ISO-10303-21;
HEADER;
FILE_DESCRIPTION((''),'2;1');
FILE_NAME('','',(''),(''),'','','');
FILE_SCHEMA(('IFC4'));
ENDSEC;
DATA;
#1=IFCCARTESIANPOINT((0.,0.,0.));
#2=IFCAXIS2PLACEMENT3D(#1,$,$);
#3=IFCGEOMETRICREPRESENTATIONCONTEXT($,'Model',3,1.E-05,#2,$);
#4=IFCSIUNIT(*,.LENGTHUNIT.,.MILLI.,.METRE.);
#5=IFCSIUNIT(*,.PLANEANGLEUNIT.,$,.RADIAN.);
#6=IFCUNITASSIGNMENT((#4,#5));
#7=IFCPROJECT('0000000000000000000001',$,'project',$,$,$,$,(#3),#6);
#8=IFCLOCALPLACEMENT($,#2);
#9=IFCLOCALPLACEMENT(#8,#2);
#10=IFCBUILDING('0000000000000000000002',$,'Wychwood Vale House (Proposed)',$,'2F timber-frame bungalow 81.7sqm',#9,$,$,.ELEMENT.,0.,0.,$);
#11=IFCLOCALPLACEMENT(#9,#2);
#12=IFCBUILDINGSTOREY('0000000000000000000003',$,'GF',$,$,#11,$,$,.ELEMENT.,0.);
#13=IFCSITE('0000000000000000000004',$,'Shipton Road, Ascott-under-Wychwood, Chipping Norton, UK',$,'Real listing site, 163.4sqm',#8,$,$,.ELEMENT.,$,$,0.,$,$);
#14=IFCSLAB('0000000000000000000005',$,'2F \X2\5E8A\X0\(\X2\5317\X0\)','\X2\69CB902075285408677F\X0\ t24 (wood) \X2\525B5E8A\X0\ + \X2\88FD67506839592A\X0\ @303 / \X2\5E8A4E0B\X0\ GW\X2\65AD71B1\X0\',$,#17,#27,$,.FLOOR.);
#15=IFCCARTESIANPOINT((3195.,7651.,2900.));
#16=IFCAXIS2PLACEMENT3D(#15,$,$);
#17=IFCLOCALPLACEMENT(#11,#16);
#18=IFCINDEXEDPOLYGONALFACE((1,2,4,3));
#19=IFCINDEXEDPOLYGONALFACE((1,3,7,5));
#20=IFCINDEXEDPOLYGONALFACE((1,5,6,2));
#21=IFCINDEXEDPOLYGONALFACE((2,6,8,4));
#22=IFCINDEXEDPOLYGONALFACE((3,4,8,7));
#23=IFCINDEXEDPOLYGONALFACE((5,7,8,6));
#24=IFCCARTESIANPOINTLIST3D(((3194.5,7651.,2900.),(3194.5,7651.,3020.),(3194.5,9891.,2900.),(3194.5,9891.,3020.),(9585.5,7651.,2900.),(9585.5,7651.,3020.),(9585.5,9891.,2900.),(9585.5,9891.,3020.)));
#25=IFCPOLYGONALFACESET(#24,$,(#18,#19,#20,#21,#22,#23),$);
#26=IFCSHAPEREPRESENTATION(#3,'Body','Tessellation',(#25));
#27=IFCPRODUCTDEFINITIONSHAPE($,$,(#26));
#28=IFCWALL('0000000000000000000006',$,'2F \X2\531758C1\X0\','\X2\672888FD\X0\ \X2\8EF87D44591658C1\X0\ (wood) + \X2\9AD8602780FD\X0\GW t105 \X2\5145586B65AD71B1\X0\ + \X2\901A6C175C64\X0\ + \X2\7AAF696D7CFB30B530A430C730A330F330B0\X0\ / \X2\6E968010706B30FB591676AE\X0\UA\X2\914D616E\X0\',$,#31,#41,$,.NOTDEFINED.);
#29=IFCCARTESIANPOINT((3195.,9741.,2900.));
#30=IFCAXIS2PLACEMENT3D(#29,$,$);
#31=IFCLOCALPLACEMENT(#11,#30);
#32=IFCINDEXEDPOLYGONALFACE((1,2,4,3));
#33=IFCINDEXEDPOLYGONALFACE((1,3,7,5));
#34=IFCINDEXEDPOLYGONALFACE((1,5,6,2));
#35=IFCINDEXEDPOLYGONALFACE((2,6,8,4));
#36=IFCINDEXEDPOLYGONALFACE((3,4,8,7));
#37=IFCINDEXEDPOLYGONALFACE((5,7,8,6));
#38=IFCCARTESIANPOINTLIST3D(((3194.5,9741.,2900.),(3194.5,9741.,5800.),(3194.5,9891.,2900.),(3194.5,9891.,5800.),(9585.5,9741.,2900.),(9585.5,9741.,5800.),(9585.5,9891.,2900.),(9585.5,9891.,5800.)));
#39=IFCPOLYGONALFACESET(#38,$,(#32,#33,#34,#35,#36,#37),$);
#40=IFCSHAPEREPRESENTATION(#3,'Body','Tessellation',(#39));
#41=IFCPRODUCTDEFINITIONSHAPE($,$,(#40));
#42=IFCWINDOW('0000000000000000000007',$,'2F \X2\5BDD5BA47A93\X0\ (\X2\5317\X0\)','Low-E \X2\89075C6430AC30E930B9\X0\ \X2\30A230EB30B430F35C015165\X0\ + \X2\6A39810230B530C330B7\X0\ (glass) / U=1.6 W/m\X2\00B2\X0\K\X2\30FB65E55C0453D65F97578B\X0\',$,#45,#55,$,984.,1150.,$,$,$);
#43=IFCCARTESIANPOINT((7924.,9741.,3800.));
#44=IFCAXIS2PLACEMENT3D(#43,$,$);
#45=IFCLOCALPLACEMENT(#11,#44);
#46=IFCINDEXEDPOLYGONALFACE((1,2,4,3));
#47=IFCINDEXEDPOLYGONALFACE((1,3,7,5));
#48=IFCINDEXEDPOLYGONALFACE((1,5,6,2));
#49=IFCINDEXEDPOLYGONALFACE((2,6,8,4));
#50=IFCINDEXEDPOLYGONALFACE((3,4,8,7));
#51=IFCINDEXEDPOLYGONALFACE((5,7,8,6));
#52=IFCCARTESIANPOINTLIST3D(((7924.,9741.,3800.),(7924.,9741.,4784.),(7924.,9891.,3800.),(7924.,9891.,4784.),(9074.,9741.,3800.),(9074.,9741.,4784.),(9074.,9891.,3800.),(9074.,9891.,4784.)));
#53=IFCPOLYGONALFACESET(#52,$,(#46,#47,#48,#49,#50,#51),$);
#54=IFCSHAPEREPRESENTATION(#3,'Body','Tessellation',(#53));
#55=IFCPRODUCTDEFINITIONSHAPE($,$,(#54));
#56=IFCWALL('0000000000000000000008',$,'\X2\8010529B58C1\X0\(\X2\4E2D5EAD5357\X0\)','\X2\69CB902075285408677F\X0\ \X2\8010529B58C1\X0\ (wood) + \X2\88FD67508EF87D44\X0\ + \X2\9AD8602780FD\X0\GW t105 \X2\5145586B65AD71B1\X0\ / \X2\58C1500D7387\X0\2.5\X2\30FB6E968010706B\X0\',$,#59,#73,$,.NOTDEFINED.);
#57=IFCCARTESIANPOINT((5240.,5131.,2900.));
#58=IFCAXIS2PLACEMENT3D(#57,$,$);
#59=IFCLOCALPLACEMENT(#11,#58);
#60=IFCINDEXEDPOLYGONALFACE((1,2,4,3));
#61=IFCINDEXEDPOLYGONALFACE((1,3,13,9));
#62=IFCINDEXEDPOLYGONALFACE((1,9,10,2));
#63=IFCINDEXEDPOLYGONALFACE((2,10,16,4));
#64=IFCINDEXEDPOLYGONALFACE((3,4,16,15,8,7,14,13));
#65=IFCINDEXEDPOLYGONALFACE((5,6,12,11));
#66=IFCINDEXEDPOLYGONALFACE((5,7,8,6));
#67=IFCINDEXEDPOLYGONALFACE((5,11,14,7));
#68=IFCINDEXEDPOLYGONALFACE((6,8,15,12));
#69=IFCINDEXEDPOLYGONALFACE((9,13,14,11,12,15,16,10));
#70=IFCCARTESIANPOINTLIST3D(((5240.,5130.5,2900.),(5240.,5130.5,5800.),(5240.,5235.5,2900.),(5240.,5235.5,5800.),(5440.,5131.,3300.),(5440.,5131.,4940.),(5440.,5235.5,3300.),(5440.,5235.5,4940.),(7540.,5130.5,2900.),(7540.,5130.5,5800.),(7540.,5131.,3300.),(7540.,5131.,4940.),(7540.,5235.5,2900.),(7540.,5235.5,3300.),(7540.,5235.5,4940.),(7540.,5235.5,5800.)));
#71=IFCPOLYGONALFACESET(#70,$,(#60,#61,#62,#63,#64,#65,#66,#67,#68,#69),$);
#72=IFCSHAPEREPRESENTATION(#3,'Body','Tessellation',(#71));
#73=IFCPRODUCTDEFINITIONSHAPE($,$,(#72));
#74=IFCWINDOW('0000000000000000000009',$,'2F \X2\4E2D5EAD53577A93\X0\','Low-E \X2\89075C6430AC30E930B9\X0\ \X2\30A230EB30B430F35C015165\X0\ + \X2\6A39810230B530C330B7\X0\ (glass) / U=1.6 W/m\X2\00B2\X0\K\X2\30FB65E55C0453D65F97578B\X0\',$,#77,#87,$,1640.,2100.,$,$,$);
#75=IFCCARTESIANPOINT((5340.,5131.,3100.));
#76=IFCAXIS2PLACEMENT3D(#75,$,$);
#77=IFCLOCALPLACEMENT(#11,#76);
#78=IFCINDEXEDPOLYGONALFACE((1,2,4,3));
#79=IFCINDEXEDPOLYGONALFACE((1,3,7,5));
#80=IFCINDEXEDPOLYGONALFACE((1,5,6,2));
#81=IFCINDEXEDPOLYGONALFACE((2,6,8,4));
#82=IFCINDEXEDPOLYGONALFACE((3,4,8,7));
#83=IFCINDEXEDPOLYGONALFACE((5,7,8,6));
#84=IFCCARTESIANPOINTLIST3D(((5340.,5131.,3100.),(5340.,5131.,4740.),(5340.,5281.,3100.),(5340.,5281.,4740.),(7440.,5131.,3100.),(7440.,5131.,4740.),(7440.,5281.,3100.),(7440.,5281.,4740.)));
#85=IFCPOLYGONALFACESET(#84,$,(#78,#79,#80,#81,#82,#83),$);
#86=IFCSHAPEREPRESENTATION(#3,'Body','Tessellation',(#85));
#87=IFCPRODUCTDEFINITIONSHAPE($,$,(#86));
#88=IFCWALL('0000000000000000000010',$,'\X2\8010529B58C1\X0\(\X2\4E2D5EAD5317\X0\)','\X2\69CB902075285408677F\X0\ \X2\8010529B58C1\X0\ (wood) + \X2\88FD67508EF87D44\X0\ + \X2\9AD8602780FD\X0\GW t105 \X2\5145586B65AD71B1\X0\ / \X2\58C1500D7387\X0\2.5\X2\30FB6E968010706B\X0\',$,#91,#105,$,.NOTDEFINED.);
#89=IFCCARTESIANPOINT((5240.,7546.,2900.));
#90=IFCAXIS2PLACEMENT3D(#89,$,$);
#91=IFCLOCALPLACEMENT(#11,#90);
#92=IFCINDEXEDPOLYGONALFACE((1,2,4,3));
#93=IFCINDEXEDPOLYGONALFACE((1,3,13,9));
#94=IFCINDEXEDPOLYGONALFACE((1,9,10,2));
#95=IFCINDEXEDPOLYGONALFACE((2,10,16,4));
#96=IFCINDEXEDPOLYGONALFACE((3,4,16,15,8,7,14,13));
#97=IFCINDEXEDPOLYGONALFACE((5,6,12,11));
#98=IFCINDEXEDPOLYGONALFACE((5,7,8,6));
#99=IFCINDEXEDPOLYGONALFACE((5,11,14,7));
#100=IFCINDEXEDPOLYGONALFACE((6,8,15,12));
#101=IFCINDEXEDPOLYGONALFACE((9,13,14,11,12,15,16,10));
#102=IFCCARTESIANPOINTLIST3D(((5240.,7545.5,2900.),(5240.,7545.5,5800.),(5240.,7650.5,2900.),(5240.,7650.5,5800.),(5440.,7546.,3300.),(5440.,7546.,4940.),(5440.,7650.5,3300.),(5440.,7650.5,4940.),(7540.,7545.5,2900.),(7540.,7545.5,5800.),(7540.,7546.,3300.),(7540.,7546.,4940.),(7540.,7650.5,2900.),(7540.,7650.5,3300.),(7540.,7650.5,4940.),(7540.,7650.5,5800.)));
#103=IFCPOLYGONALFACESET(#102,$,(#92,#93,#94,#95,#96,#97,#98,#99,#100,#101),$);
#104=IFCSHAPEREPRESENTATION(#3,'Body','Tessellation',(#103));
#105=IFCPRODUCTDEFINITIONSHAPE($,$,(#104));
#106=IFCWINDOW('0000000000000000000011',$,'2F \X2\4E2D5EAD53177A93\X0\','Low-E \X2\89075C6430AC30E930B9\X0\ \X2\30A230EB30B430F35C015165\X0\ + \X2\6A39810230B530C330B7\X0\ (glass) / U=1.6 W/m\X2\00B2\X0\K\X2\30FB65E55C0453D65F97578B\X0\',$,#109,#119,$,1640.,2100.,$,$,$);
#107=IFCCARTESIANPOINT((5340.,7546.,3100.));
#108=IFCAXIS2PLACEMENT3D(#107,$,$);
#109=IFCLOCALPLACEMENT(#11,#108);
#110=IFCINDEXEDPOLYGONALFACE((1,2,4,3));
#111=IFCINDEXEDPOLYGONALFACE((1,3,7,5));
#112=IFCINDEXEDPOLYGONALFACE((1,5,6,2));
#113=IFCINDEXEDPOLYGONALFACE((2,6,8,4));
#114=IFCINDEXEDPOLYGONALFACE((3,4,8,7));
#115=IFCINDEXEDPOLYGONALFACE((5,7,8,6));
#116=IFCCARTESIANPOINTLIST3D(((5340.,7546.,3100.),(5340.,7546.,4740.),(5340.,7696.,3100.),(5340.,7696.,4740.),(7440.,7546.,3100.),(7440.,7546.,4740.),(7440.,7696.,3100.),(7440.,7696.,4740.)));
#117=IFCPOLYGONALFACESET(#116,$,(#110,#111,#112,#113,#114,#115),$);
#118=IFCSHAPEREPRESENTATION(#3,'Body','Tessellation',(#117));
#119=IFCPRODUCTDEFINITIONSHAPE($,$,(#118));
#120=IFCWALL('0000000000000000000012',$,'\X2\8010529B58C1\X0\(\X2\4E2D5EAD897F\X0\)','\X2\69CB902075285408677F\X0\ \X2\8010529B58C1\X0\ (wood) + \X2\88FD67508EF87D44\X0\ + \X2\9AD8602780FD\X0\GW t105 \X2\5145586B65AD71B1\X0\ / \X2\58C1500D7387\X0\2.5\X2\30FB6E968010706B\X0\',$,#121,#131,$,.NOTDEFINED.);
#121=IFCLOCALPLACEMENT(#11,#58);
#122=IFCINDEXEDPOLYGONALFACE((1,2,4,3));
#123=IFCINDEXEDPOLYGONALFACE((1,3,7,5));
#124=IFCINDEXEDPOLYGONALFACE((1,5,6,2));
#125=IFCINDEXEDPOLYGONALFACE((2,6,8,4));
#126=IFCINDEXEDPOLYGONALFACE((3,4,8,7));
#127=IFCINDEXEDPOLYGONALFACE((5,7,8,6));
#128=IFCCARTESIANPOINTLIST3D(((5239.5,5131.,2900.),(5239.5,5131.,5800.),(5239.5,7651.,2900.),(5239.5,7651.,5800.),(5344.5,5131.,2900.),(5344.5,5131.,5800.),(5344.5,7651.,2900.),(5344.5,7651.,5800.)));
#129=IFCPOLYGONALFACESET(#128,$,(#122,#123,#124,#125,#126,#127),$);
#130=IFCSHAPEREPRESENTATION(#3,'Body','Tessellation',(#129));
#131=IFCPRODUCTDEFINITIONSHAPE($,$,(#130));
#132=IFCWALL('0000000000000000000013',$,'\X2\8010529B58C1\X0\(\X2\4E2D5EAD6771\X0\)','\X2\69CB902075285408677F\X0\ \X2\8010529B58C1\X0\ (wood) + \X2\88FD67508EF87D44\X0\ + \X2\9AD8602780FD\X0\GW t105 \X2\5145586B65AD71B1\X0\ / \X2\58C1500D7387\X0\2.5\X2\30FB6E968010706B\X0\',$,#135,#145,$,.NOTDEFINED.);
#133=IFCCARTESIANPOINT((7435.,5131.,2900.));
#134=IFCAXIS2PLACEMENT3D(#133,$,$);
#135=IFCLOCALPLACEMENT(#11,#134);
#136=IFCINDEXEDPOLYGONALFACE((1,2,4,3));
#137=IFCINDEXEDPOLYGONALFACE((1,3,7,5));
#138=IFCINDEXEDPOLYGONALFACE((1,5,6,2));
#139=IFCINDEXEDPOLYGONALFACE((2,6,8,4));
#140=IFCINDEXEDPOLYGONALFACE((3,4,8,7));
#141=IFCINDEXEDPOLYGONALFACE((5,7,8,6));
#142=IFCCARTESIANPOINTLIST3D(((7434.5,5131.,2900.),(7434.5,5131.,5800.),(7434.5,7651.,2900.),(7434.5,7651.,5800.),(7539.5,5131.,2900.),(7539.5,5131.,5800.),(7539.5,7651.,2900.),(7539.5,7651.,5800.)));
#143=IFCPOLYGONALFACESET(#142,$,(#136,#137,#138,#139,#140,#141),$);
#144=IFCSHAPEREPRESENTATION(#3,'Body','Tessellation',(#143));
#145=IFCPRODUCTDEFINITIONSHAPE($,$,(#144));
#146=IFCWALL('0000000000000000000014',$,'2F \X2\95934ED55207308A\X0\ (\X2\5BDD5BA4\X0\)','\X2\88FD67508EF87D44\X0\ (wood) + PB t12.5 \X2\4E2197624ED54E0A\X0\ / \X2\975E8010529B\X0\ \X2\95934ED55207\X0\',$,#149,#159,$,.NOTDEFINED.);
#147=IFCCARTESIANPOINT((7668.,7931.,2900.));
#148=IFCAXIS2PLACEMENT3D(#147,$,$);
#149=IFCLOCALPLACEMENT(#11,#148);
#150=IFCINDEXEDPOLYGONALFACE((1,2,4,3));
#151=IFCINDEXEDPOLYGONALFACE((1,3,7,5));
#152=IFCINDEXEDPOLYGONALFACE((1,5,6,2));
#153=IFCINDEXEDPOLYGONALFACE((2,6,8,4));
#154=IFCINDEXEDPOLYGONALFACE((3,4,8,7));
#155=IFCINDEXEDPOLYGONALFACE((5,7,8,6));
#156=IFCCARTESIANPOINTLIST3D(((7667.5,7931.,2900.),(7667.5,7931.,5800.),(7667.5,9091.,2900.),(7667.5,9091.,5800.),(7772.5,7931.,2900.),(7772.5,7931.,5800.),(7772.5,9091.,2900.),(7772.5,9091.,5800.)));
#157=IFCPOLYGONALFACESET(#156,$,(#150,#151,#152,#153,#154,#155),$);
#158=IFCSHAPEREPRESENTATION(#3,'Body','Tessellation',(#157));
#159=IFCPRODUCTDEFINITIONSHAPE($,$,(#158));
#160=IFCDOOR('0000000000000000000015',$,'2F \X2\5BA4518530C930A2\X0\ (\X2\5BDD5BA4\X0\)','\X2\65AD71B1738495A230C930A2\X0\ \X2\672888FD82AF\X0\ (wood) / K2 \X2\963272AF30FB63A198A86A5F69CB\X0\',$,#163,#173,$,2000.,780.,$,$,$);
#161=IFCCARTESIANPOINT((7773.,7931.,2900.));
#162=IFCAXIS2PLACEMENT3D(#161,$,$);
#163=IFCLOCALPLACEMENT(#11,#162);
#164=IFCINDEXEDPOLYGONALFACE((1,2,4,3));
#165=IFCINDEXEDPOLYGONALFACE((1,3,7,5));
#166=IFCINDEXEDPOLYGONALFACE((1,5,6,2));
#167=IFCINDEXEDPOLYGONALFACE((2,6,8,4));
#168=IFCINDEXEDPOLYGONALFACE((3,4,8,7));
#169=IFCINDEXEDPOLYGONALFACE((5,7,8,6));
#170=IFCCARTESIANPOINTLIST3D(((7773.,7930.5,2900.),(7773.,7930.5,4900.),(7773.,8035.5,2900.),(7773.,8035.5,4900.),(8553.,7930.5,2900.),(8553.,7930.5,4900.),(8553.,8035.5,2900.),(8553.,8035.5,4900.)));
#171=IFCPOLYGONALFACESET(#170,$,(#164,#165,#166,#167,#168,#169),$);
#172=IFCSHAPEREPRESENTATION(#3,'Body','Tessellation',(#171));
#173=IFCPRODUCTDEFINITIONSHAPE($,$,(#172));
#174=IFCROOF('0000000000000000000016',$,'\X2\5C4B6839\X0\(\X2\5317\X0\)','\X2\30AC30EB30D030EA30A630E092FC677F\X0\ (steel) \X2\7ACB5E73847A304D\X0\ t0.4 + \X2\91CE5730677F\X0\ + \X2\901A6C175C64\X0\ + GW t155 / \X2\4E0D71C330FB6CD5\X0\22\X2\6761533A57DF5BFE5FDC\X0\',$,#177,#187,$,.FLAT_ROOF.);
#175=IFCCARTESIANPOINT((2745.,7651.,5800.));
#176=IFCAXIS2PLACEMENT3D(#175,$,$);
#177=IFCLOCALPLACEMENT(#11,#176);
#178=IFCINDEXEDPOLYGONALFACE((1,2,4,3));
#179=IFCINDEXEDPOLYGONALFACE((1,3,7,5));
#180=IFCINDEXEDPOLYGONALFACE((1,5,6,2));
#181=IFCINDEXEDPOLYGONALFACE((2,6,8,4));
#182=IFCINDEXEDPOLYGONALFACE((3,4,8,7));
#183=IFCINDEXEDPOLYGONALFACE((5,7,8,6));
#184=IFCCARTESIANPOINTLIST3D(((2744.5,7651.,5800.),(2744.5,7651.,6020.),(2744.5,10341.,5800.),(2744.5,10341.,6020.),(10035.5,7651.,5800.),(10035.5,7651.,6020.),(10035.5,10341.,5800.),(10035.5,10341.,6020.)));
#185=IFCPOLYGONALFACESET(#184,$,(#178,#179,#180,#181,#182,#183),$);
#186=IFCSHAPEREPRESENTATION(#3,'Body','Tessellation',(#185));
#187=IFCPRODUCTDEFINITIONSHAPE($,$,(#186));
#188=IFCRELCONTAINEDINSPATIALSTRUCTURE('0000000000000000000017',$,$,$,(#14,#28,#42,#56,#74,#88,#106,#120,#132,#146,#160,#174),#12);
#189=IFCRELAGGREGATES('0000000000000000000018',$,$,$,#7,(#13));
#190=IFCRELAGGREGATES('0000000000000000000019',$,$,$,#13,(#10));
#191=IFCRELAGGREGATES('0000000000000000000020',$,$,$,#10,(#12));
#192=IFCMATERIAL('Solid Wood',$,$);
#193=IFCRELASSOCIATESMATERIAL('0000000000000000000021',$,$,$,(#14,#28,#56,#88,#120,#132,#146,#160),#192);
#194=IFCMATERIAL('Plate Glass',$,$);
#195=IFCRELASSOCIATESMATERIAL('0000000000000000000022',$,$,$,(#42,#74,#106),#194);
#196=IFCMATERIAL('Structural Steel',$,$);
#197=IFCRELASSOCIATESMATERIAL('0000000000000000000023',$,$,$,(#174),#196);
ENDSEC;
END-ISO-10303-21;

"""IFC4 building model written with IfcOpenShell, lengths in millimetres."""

from ifc_helpers import new_model, si_unit, frame, frame_2d, origin, place, context, project, spatial, rectangle, extrude, material, element, fill, save


model = new_model("IFC4")

# Units and contexts
model_context = context("Model", 3, precision=1e-05, world=origin())
ifc_project = project(units=[si_unit("LENGTHUNIT", "METRE", prefix="MILLI"), si_unit("PLANEANGLEUNIT", "RADIAN")], contexts=[model_context])

# Site, building, storey
site_placement = place(None, origin())
site = spatial("IfcSite", under=ifc_project, at=site_placement, Name="Shipton Road, Ascott-under-Wychwood, Chipping Norton, UK", ObjectType="Real listing site, 163.4sqm", CompositionType="ELEMENT", RefElevation=0.0)
building_placement = place(site_placement, origin())
building = spatial("IfcBuilding", under=site, at=building_placement, Name="Wychwood Vale House (Proposed)", ObjectType="2F timber-frame bungalow 81.7sqm", CompositionType="ELEMENT", ElevationOfRefHeight=0.0, ElevationOfTerrain=0.0)
storey_placement = place(building_placement, origin())
storey = spatial("IfcBuildingStorey", under=building, at=storey_placement, Name="GF", CompositionType="ELEMENT", Elevation=0.0)

# Slab
ifc_material_1 = material(Name="Solid Wood")
slab_placement = place(storey_placement, frame((3195.0, 7651.0, 2900.0)))
element("IfcSlab", 1, at=slab_placement, inside=storey, material=ifc_material_1, Name="2F 床(北)", Description="構造用合板 t24 (wood) 剛床 + 製材根太 @303 / 床下 GW断熱", PredefinedType="FLOOR", context=model_context, shape_type="SweptSolid", body=[
    extrude(rectangle(XDim=6391.0, YDim=2240.0, at=frame_2d((3195.0, 1120.0))), frame((3195.0, 7651.0, 2900.0)), (0.0, 0.0, 1.0), 120.0),
])

# Walls, openings, windows
wall_1_placement = place(storey_placement, frame((3195.0, 9741.0, 2900.0)))
wall_1 = element("IfcWall", 2, at=wall_1_placement, inside=storey, material=ifc_material_1, Name="2F 北壁", Description="木製 軸組外壁 (wood) + 高性能GW t105 充填断熱 + 通気層 + 窯業系サイディング / 準耐火・外皮UA配慮", PredefinedType="NOTDEFINED", context=model_context, shape_type="SweptSolid", body=[
    extrude(rectangle(XDim=6391.0, YDim=150.0, at=frame_2d((3195.0, 75.0))), frame((3195.0, 9741.0, 2900.0)), (0.0, 0.0, 1.0), 2900.0),
])
opening_1_placement = place(storey_placement, frame((7924.0, 9741.0, 3800.0)))
opening_1 = element("IfcOpeningElement", 3, at=opening_1_placement, cuts=wall_1, PredefinedType="NOTDEFINED", context=model_context, shape_type="SweptSolid", body=[
    extrude(rectangle(XDim=1150.0, YDim=150.0, at=frame_2d((575.0, 75.0))), frame((7924.0, 9741.0, 3800.0)), (0.0, 0.0, 1.0), 984.0),
])
ifc_material_2 = material(Name="Plate Glass")
window_1_placement = place(storey_placement, frame((7924.0, 9741.0, 3800.0)))
window_1 = element("IfcWindow", 4, at=window_1_placement, inside=storey, material=ifc_material_2, Name="2F 寝室窓 (北)", Description="Low-E 複層ガラス アルゴン封入 + 樹脂サッシ (glass) / U=1.6 W/m²K・日射取得型", OverallHeight=984.0, OverallWidth=1150.0, context=model_context, shape_type="SweptSolid", body=[
    extrude(rectangle(XDim=1150.0, YDim=150.0, at=frame_2d((575.0, 75.0))), frame((7924.0, 9741.0, 3800.0)), (0.0, 0.0, 1.0), 984.0),
])
fill(opening_1, window_1)
wall_2_placement = place(storey_placement, frame((5240.0, 5131.0, 2900.0)))
wall_2 = element("IfcWall", 5, at=wall_2_placement, inside=storey, material=ifc_material_1, Name="耐力壁(中庭南)", Description="構造用合板 耐力壁 (wood) + 製材軸組 + 高性能GW t105 充填断熱 / 壁倍率2.5・準耐火", PredefinedType="NOTDEFINED", context=model_context, shape_type="SweptSolid", body=[
    extrude(rectangle(XDim=2300.0, YDim=105.0, at=frame_2d((1150.0, 52.0))), frame((5240.0, 5131.0, 2900.0)), (0.0, 0.0, 1.0), 2900.0),
])
opening_2_placement = place(storey_placement, frame((5340.0, 5131.0, 3100.0)))
opening_2 = element("IfcOpeningElement", 6, at=opening_2_placement, cuts=wall_2, PredefinedType="NOTDEFINED", context=model_context, shape_type="SweptSolid", body=[
    extrude(rectangle(XDim=2100.0, YDim=150.0, at=frame_2d((1050.0, 75.0))), frame((5340.0, 5131.0, 3100.0)), (0.0, 0.0, 1.0), 1640.0),
])
window_2_placement = place(storey_placement, frame((5340.0, 5131.0, 3100.0)))
window_2 = element("IfcWindow", 7, at=window_2_placement, inside=storey, material=ifc_material_2, Name="2F 中庭南窓", Description="Low-E 複層ガラス アルゴン封入 + 樹脂サッシ (glass) / U=1.6 W/m²K・日射取得型", OverallHeight=1640.0, OverallWidth=2100.0, context=model_context, shape_type="SweptSolid", body=[
    extrude(rectangle(XDim=2100.0, YDim=150.0, at=frame_2d((1050.0, 75.0))), frame((5340.0, 5131.0, 3100.0)), (0.0, 0.0, 1.0), 1640.0),
])
fill(opening_2, window_2)
wall_3_placement = place(storey_placement, frame((5240.0, 7546.0, 2900.0)))
wall_3 = element("IfcWall", 8, at=wall_3_placement, inside=storey, material=ifc_material_1, Name="耐力壁(中庭北)", Description="構造用合板 耐力壁 (wood) + 製材軸組 + 高性能GW t105 充填断熱 / 壁倍率2.5・準耐火", PredefinedType="NOTDEFINED", context=model_context, shape_type="SweptSolid", body=[
    extrude(rectangle(XDim=2300.0, YDim=105.0, at=frame_2d((1150.0, 52.0))), frame((5240.0, 7546.0, 2900.0)), (0.0, 0.0, 1.0), 2900.0),
])
opening_3_placement = place(storey_placement, frame((5340.0, 7546.0, 3100.0)))
opening_3 = element("IfcOpeningElement", 9, at=opening_3_placement, cuts=wall_3, PredefinedType="NOTDEFINED", context=model_context, shape_type="SweptSolid", body=[
    extrude(rectangle(XDim=2100.0, YDim=150.0, at=frame_2d((1050.0, 75.0))), frame((5340.0, 7546.0, 3100.0)), (0.0, 0.0, 1.0), 1640.0),
])
window_3_placement = place(storey_placement, frame((5340.0, 7546.0, 3100.0)))
window_3 = element("IfcWindow", 10, at=window_3_placement, inside=storey, material=ifc_material_2, Name="2F 中庭北窓", Description="Low-E 複層ガラス アルゴン封入 + 樹脂サッシ (glass) / U=1.6 W/m²K・日射取得型", OverallHeight=1640.0, OverallWidth=2100.0, context=model_context, shape_type="SweptSolid", body=[
    extrude(rectangle(XDim=2100.0, YDim=150.0, at=frame_2d((1050.0, 75.0))), frame((5340.0, 7546.0, 3100.0)), (0.0, 0.0, 1.0), 1640.0),
])
fill(opening_3, window_3)

# Walls
wall_4_placement = place(storey_placement, frame((5240.0, 5131.0, 2900.0)))
element("IfcWall", 11, at=wall_4_placement, inside=storey, material=ifc_material_1, Name="耐力壁(中庭西)", Description="構造用合板 耐力壁 (wood) + 製材軸組 + 高性能GW t105 充填断熱 / 壁倍率2.5・準耐火", PredefinedType="NOTDEFINED", context=model_context, shape_type="SweptSolid", body=[
    extrude(rectangle(XDim=105.0, YDim=2520.0, at=frame_2d((52.0, 1260.0))), frame((5240.0, 5131.0, 2900.0)), (0.0, 0.0, 1.0), 2900.0),
])
wall_5_placement = place(storey_placement, frame((7435.0, 5131.0, 2900.0)))
element("IfcWall", 12, at=wall_5_placement, inside=storey, material=ifc_material_1, Name="耐力壁(中庭東)", Description="構造用合板 耐力壁 (wood) + 製材軸組 + 高性能GW t105 充填断熱 / 壁倍率2.5・準耐火", PredefinedType="NOTDEFINED", context=model_context, shape_type="SweptSolid", body=[
    extrude(rectangle(XDim=105.0, YDim=2520.0, at=frame_2d((52.0, 1260.0))), frame((7435.0, 5131.0, 2900.0)), (0.0, 0.0, 1.0), 2900.0),
])
wall_6_placement = place(storey_placement, frame((7668.0, 7931.0, 2900.0)))
element("IfcWall", 13, at=wall_6_placement, inside=storey, material=ifc_material_1, Name="2F 間仕切り (寝室)", Description="製材軸組 (wood) + PB t12.5 両面仕上 / 非耐力 間仕切", PredefinedType="NOTDEFINED", context=model_context, shape_type="SweptSolid", body=[
    extrude(rectangle(XDim=105.0, YDim=1160.0, at=frame_2d((52.0, 580.0))), frame((7668.0, 7931.0, 2900.0)), (0.0, 0.0, 1.0), 2900.0),
])

# Door
door_placement = place(storey_placement, frame((7773.0, 7931.0, 2900.0)))
element("IfcDoor", 14, at=door_placement, inside=storey, material=ifc_material_1, Name="2F 室内ドア (寝室)", Description="断熱玄関ドア 木製芯 (wood) / K2 防犯・採風機構", OverallHeight=2000.0, OverallWidth=780.0, context=model_context, shape_type="SweptSolid", body=[
    extrude(rectangle(XDim=780.0, YDim=105.0, at=frame_2d((390.0, 52.0))), frame((7773.0, 7931.0, 2900.0)), (0.0, 0.0, 1.0), 2000.0),
])

# Roof
ifc_material_3 = material(Name="Structural Steel")
for number, where, name in (
    (15, (2745.0, 7651.0, 5800.0), "屋根(北)"),
):
    element("IfcRoof", number, at=place(storey_placement, frame(where)), inside=storey, material=ifc_material_3, Name=name, Description="ガルバリウム鋼板 (steel) 立平葺き t0.4 + 野地板 + 通気層 + GW t155 / 不燃・法22条区域対応", PredefinedType="FLAT_ROOF", context=model_context, shape_type="SweptSolid", body=[
        extrude(rectangle(XDim=7291.0, YDim=2690.0, at=frame_2d((3645.0, 1345.0))), frame((2745.0, 7651.0, 5800.0)), (0.0, 0.0, 1.0), 220.0),
    ])

save(model, "model.ifc")
